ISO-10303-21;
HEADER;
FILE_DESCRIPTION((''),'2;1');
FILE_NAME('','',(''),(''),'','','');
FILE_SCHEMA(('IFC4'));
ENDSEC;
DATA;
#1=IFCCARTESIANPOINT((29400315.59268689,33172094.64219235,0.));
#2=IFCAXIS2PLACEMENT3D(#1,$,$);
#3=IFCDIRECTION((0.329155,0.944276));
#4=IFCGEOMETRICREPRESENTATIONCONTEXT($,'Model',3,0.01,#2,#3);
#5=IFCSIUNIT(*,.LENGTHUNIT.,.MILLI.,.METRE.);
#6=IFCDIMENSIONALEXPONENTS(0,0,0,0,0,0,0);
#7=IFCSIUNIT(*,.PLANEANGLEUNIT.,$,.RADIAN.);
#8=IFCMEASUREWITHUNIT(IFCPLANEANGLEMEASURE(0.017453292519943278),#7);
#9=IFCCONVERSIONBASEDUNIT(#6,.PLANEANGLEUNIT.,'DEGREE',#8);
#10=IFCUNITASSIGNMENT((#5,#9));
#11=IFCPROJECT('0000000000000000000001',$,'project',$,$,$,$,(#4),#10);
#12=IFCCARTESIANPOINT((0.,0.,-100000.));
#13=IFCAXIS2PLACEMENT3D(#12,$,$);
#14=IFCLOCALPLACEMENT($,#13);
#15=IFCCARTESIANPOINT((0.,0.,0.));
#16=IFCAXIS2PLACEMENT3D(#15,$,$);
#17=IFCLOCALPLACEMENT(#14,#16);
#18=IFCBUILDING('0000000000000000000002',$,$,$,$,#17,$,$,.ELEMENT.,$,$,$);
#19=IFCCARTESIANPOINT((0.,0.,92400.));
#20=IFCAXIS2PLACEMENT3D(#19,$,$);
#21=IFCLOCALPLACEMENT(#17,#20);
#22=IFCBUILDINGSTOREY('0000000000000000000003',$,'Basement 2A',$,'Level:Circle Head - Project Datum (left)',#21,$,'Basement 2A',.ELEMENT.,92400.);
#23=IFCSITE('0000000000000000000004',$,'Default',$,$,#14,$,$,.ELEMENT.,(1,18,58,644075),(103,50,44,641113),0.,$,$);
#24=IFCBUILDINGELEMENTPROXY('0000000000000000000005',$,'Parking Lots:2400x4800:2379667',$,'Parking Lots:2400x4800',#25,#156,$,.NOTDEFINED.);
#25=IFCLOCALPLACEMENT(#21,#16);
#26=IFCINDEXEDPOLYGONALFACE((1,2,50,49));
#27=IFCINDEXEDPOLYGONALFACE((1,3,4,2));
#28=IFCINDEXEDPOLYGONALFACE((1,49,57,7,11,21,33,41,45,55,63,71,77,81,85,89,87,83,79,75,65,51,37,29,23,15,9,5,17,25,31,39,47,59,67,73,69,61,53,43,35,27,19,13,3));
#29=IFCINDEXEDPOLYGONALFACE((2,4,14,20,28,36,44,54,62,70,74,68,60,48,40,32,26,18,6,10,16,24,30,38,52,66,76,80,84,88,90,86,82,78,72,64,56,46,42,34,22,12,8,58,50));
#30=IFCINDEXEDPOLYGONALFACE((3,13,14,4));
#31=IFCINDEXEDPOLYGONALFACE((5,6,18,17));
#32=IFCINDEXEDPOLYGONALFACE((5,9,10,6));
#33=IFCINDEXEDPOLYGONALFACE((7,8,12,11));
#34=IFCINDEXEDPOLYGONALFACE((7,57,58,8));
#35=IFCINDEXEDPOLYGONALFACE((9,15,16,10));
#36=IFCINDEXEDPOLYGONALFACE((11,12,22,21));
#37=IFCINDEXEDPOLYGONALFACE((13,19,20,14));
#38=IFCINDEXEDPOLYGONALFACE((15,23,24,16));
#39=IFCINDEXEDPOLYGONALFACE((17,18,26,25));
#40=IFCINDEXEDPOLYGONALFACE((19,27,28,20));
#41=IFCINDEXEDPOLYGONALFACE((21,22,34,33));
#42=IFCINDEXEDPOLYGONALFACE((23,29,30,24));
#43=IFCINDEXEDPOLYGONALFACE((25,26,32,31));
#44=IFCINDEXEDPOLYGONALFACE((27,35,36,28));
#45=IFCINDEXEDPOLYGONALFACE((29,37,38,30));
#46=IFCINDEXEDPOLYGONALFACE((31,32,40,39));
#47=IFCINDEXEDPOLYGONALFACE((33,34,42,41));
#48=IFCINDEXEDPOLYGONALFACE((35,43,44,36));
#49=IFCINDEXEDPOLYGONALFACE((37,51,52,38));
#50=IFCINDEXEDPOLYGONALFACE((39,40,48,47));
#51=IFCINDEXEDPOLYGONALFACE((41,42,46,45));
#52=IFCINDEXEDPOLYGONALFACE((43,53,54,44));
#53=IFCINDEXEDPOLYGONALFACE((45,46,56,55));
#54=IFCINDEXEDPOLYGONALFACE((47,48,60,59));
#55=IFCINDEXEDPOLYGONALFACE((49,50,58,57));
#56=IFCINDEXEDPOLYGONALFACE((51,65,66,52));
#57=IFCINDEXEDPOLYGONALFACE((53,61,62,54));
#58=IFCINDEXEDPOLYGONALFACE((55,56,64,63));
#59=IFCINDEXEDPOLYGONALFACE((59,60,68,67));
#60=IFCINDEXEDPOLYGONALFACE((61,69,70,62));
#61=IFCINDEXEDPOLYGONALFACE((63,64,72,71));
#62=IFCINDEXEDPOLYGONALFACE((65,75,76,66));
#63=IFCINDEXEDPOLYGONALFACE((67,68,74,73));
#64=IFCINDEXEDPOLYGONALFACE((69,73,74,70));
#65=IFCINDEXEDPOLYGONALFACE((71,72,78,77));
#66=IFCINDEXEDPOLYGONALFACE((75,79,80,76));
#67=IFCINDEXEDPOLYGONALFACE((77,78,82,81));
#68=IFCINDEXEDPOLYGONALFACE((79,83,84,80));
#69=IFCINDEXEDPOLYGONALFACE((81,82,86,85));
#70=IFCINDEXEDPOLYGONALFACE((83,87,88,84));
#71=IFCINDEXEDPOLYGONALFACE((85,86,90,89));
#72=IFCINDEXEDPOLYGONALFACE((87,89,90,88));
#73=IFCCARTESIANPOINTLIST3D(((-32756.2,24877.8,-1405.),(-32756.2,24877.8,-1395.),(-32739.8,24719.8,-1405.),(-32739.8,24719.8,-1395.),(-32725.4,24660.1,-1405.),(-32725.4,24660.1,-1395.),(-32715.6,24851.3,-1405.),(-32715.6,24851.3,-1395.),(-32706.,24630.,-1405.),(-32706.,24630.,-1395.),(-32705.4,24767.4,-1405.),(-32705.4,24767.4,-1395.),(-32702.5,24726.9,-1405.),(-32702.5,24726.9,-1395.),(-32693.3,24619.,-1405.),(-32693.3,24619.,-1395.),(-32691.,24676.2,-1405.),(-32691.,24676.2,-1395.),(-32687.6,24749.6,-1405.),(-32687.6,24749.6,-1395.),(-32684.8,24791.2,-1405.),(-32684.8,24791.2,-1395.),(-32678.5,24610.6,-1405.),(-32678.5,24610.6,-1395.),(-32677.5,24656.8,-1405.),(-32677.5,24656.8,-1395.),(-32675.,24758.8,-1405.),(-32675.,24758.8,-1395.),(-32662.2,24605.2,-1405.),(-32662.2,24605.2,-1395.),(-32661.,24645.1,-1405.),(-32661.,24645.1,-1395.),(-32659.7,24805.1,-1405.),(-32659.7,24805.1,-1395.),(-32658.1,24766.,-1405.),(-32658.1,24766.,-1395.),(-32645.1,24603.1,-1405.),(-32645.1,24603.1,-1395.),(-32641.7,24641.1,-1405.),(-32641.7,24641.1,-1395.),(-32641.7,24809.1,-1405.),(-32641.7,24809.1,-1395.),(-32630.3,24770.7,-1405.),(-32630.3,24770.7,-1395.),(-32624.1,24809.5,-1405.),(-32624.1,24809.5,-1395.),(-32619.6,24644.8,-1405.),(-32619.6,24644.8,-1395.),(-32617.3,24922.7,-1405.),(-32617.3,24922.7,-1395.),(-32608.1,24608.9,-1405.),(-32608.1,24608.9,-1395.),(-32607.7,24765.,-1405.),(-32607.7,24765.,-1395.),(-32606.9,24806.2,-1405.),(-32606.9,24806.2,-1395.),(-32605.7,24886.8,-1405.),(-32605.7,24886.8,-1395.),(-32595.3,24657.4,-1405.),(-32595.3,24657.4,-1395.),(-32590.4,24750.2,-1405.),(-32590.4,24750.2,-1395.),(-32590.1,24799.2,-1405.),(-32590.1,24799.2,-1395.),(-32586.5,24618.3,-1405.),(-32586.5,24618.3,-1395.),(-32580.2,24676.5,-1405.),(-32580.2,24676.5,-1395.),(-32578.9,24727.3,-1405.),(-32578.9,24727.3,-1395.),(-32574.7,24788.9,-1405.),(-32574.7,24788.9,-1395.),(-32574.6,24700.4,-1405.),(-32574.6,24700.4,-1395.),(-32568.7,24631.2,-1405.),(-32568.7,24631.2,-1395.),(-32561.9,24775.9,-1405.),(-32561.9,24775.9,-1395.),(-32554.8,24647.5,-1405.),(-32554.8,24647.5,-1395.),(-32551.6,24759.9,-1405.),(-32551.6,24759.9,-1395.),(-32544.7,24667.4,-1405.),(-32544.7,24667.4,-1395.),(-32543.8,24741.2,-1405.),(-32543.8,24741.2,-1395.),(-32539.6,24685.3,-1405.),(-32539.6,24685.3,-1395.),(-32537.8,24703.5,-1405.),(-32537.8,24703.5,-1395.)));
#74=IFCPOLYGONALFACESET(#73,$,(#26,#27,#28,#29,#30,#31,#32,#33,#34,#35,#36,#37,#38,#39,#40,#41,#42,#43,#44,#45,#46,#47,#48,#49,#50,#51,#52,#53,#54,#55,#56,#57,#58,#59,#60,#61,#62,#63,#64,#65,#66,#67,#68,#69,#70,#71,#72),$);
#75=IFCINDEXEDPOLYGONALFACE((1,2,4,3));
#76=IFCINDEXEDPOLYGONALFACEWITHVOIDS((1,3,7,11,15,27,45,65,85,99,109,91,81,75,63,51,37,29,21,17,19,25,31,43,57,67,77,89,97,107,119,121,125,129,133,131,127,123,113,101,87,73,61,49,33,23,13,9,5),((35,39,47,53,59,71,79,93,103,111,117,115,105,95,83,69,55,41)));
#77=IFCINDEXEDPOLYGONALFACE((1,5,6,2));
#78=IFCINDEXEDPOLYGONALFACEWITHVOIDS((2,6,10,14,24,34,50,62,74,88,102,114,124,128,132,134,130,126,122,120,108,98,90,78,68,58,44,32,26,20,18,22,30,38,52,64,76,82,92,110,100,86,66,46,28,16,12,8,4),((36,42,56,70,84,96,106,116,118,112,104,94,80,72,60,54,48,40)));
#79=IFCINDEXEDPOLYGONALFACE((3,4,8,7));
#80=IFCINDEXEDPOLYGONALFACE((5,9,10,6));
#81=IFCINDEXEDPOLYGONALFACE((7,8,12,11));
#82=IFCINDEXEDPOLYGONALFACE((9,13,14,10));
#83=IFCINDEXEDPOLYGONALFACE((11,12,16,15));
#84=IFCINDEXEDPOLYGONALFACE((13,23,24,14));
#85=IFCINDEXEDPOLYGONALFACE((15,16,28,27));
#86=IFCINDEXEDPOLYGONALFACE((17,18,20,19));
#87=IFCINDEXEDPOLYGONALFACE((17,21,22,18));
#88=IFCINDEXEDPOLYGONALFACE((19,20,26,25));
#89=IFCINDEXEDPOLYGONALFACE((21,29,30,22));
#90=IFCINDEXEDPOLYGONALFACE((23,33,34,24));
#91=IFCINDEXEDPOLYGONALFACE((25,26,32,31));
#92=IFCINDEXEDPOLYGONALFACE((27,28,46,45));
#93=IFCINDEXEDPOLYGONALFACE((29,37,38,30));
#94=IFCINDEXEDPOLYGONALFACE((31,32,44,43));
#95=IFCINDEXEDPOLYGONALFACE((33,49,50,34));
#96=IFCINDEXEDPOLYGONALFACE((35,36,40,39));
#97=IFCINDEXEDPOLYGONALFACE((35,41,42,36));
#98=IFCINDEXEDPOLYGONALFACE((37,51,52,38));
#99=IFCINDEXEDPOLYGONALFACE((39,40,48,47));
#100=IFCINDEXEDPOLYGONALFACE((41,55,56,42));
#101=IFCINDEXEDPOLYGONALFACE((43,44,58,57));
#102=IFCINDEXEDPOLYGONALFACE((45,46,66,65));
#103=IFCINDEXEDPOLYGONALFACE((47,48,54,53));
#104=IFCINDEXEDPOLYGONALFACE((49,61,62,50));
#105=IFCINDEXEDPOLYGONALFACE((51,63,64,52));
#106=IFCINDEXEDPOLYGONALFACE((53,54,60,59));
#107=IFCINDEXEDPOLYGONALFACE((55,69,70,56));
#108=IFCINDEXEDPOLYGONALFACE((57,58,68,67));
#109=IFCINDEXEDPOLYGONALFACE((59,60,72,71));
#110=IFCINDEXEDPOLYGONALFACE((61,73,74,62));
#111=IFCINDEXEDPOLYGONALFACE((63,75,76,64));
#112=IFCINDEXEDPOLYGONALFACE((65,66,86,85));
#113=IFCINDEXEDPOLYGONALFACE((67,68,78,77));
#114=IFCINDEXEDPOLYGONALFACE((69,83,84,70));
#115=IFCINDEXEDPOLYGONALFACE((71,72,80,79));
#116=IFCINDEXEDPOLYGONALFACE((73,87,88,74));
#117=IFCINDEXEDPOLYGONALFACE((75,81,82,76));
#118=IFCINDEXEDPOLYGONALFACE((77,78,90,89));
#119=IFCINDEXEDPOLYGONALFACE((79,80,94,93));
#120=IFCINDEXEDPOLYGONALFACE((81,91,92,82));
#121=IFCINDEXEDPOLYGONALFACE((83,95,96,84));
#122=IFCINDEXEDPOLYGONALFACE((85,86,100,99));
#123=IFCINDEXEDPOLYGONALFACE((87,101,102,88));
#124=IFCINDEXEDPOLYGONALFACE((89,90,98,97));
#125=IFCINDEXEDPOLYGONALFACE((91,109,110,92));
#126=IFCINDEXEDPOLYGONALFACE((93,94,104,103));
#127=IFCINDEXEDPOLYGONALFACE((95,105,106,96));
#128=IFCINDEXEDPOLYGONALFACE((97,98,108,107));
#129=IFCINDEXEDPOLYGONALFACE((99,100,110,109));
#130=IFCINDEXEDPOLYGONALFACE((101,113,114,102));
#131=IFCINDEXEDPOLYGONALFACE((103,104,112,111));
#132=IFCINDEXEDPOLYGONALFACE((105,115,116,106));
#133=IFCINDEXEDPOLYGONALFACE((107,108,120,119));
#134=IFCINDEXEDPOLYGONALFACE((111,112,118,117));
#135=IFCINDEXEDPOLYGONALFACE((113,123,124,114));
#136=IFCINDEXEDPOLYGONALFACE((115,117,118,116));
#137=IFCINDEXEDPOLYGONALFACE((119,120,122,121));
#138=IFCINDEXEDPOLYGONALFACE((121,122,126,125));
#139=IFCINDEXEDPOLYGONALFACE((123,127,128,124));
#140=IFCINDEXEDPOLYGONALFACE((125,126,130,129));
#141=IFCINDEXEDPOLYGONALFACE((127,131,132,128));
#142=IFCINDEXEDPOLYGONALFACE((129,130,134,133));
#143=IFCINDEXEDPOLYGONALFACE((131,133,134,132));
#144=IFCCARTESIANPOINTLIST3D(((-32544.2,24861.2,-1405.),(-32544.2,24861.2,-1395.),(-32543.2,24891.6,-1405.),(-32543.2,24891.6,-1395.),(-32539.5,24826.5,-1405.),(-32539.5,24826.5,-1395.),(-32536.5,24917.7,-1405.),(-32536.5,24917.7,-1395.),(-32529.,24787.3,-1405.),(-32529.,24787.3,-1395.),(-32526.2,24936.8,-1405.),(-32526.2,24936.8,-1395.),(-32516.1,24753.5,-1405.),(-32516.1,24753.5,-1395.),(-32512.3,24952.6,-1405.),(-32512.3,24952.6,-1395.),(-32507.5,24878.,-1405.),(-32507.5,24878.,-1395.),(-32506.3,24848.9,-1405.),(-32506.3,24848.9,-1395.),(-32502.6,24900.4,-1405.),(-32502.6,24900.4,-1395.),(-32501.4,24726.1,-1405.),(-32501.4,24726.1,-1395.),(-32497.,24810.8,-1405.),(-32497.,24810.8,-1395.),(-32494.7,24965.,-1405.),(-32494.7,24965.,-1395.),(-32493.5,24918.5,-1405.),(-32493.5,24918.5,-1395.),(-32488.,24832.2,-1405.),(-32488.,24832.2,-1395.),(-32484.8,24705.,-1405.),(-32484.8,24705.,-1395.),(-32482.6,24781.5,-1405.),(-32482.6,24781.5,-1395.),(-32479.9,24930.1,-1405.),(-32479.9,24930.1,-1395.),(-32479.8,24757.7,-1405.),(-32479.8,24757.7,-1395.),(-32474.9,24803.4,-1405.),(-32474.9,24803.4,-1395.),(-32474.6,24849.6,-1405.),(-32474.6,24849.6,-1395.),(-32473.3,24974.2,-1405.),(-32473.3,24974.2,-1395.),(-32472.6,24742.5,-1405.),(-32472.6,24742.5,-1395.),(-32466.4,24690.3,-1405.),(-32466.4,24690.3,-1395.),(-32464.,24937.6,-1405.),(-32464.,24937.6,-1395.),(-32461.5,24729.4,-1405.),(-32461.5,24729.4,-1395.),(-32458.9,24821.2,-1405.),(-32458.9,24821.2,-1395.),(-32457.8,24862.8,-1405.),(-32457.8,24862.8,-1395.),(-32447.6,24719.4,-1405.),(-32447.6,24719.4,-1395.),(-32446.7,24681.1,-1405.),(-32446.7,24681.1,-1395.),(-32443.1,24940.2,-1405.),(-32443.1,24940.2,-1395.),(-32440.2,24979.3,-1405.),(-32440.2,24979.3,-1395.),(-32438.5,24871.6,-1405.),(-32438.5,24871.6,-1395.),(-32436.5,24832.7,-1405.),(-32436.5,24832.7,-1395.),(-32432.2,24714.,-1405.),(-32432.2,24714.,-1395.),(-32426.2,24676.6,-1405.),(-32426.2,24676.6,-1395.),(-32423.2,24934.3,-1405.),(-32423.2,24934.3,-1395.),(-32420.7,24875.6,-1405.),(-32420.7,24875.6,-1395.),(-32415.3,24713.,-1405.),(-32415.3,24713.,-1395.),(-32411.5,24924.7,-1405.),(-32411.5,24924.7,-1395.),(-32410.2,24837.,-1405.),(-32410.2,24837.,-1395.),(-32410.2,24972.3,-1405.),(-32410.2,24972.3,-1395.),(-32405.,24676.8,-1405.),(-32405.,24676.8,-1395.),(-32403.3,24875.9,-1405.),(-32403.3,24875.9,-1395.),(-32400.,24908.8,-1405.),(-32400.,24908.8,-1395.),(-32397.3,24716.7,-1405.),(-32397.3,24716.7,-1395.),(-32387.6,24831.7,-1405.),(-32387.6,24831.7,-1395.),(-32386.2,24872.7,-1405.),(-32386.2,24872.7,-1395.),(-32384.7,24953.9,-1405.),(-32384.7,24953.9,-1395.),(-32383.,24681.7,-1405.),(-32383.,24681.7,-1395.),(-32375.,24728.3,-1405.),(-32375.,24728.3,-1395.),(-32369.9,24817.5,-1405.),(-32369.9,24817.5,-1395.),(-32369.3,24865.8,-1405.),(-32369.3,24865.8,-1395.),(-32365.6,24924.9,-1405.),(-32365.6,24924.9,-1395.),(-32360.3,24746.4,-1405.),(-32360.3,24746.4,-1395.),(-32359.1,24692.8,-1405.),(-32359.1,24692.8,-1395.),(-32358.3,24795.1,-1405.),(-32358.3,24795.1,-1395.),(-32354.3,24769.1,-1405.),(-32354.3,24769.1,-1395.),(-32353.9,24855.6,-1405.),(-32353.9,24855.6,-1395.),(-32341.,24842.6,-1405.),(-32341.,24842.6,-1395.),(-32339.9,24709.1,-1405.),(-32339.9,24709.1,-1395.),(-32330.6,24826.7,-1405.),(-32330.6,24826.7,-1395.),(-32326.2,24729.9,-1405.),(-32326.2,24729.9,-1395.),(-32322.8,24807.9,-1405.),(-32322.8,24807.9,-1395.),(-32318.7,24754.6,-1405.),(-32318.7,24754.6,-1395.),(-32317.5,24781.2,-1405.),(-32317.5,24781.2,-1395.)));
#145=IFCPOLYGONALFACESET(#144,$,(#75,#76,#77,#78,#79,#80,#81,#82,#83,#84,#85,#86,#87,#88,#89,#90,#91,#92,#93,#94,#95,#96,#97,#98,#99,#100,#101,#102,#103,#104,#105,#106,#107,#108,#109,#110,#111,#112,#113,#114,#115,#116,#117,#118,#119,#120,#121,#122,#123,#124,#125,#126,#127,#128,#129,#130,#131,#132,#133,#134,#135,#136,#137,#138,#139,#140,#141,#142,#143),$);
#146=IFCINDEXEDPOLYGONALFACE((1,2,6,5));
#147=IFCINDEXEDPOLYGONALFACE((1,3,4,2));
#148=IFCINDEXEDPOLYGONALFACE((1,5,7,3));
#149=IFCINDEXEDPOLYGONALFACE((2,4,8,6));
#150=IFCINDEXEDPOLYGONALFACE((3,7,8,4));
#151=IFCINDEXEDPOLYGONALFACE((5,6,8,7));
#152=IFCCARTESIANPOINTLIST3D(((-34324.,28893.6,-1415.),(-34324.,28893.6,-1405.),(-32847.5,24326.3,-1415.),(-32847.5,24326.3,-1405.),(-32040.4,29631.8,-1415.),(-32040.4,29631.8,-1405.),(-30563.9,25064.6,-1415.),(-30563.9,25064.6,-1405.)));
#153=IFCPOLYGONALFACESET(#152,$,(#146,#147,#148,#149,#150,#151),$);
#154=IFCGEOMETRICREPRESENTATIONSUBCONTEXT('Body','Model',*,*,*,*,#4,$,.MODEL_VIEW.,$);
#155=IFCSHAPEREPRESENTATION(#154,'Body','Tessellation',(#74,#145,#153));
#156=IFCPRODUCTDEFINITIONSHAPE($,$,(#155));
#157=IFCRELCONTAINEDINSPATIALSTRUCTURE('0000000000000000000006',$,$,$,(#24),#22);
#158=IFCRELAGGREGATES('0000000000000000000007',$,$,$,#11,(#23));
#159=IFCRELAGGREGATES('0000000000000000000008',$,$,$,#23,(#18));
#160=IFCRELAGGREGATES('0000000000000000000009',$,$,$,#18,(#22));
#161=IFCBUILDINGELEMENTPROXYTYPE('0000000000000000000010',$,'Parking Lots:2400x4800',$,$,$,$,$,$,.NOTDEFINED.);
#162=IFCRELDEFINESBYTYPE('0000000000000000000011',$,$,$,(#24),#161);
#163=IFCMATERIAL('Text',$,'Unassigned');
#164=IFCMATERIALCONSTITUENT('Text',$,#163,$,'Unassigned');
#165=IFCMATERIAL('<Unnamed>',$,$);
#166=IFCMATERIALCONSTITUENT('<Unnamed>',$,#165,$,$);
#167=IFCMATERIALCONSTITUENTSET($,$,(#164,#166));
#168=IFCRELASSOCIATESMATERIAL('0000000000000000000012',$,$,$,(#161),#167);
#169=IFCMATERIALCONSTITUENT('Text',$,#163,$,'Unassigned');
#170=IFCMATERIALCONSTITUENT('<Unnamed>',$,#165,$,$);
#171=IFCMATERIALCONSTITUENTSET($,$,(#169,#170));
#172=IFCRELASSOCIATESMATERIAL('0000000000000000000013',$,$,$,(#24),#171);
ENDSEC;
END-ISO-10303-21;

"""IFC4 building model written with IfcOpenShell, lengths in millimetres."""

from ifc_helpers import new_model, entity, si_unit, converted_unit, direction, frame, origin, place, context, subcontext, project, spatial, indexed_curve, outline, extrude, source, transform, mapped, material, constituent, constituent_set, type_object, type_shapes, element, save


model = new_model("IFC4")

# Units and contexts
model_context = context("Model", 3, precision=0.01, world=frame((29400315.59268689, 33172094.64219235, 0.0)), true_north=direction((0.329155, 0.944276)))
body_context = subcontext(model_context, "Body", "Model", "MODEL_VIEW")
ifc_project = project(units=[si_unit("LENGTHUNIT", "METRE", prefix="MILLI"), converted_unit("PLANEANGLEUNIT", "DEGREE", entity("IfcPlaneAngleMeasure", 0.017453292519943278), si_unit("PLANEANGLEUNIT", "RADIAN"), dimensions=[0, 0, 0, 0, 0, 0, 0])], contexts=[model_context])

# Site, building, storey
site_placement = place(None, frame((0.0, 0.0, -100000.0)))
site = spatial("IfcSite", under=ifc_project, at=site_placement, Name="Default", CompositionType="ELEMENT", RefLatitude=(1, 18, 58, 644075), RefLongitude=(103, 50, 44, 641113), RefElevation=0.0)
building_placement = place(site_placement, origin())
building = spatial("IfcBuilding", under=site, at=building_placement, CompositionType="ELEMENT")
storey_placement = place(building_placement, frame((0.0, 0.0, 92400.0)))
storey = spatial("IfcBuildingStorey", under=building, at=storey_placement, Name="Basement 2A", ObjectType="Level:Circle Head - Project Datum (left)", LongName="Basement 2A", CompositionType="ELEMENT", Elevation=92400.0)

# Building element proxy
ifc_material_1 = material(Name="Text", Category="Unassigned")
ifc_material_2 = material(Name="<Unnamed>")
ifc_constituent_1 = constituent(ifc_material_1, Name="Text", Category="Unassigned")
ifc_constituent_2 = constituent(ifc_material_2, Name="<Unnamed>")
ifc_constituent_set_1 = constituent_set(constituents=[ifc_constituent_1, ifc_constituent_2])
ifc_constituent_3 = constituent(ifc_material_1, Name="Text", Category="Unassigned")
ifc_constituent_4 = constituent(ifc_material_2, Name="<Unnamed>")
ifc_constituent_set_2 = constituent_set(constituents=[ifc_constituent_3, ifc_constituent_4])
building_element_proxy_type_1 = type_object("IfcBuildingElementProxyType", Name="Parking Lots:2400x4800", PredefinedType="NOTDEFINED", material=ifc_constituent_set_2)
shared_shape_1 = source(origin(), body_context, "Body", "SweptSolid", [
    extrude(outline(indexed_curve([(1.4, -113.1), (37.2, -113.1), (53.4, -108.4), (68.5, -100.5), (81.8, -89.8), (92.9, -76.5), (108.0, -42.2), (111.8, -18.9), (110.6, 3.0), (104.4, 23.5), (93.2, 42.7), (80.9, 56.7), (66.6, 68.1), (31.7, 83.5), (11.7, 87.1), (-7.3, 87.1), (-25.2, 83.4), (-42.2, 76.0), (-57.1, 65.7), (-69.2, 53.0), (-78.5, 38.0), (-84.8, 20.7), (-86.8, -7.9), (-77.9, -38.1), (-154.0, -1.2), (-124.3, 110.4), (-160.7, 120.1), (-198.2, -21.0), (-56.5, -92.8), (-42.3, -57.6), (-53.3, -32.8), (-54.2, -17.2), (-51.1, 0.9), (-40.0, 26.8), (-23.0, 42.8), (-1.2, 49.2), (24.3, 46.5), (49.2, 35.5), (66.3, 17.9), (74.2, -5.1), (71.6, -32.4), (62.8, -53.0), (48.9, -67.1), (30.2, -74.6), (6.6, -75.5), (1.4, -113.1)], self_intersect=False)), frame((327.7, -4489.5, 10.0), z_axis=(0.0, 0.0, 1.0), x_axis=(0.256974, -0.966418, 0.0)), (0.0, 0.0, 1.0), 10.0),
    extrude(outline(indexed_curve([(26.9, -105.5), (61.6, -105.5), (91.0, -94.4), (113.4, -73.2), (127.3, -42.7), (131.4, -19.9), (130.7, 1.7), (125.2, 22.0), (114.9, 41.1), (96.9, 61.1), (72.1, 78.6), (40.4, 93.8), (2.0, 106.6), (-33.3, 114.5), (-64.3, 117.3), (-91.0, 115.0), (-113.4, 107.8), (-132.0, 96.4), (-147.0, 81.8), (-158.5, 63.9), (-166.6, 42.8), (-170.5, 16.8), (-167.4, -8.2), (-157.6, -31.1), (-141.1, -50.9), (-119.5, -66.6), (-94.3, -76.8), (-74.4, -80.6), (-55.4, -80.8), (-37.4, -77.2), (-20.4, -69.9), (-5.4, -59.6), (6.8, -47.1), (16.1, -32.4), (22.5, -15.4), (25.8, 5.6), (24.1, 26.9), (16.9, 47.7), (4.0, 67.0), (40.9, 53.7), (65.8, 38.7), (81.8, 22.3), (92.0, 4.8), (94.1, -12.9), (91.7, -30.4), (82.4, -49.3), (66.5, -62.6), (52.0, -67.1), (32.4, -68.0), (26.9, -105.5)], self_intersect=False), holes=[indexed_curve([(-49.8, 81.9), (-28.4, 71.1), (-14.3, 52.6), (-8.3, 29.4), (-11.1, 4.4), (-21.9, -19.9), (-38.8, -35.8), (-60.4, -42.8), (-85.5, -40.2), (-109.3, -29.2), (-125.1, -11.7), (-132.0, 10.5), (-129.5, 35.6), (-122.6, 52.6), (-112.6, 66.2), (-99.5, 76.0), (-83.5, 82.2), (-66.4, 84.2), (-49.8, 81.9)], self_intersect=False)]), frame((548.1, -4432.8, 10.0), z_axis=(0.0, 0.0, 1.0), x_axis=(-0.267015, 0.963692, 0.0)), (0.0, 0.0, 1.0), 10.0),
    extrude(outline(indexed_curve([(-1200.0, -2400.0), (1200.0, -2400.0), (1200.0, 2400.0), (-1200.0, 2400.0), (-1200.0, -2400.0)], self_intersect=False)), frame((1200.0, -2400.0, 0.0), z_axis=(0.0, 0.0, 1.0), x_axis=(-1.0, 0.0, 0.0)), (0.0, 0.0, 1.0), 10.0),
])
type_shapes(building_element_proxy_type_1, [shared_shape_1])
proxy_1_placement = place(storey_placement, frame((-34324.0, 28893.6, -1415.0), z_axis=(0.0, 0.0, 1.0), x_axis=(0.951511, 0.307614, 0.0)))
element("IfcBuildingElementProxy", 1, at=proxy_1_placement, inside=storey, type_object=building_element_proxy_type_1, material=ifc_constituent_set_1, Name="Parking Lots:2400x4800:2379667", ObjectType="Parking Lots:2400x4800", PredefinedType="NOTDEFINED", context=body_context, shape_type="MappedRepresentation", body=[
    mapped(shared_shape_1, transform((0.0, 0.0, 0.0), scale=1.0)),
])

save(model, "model.ifc")
